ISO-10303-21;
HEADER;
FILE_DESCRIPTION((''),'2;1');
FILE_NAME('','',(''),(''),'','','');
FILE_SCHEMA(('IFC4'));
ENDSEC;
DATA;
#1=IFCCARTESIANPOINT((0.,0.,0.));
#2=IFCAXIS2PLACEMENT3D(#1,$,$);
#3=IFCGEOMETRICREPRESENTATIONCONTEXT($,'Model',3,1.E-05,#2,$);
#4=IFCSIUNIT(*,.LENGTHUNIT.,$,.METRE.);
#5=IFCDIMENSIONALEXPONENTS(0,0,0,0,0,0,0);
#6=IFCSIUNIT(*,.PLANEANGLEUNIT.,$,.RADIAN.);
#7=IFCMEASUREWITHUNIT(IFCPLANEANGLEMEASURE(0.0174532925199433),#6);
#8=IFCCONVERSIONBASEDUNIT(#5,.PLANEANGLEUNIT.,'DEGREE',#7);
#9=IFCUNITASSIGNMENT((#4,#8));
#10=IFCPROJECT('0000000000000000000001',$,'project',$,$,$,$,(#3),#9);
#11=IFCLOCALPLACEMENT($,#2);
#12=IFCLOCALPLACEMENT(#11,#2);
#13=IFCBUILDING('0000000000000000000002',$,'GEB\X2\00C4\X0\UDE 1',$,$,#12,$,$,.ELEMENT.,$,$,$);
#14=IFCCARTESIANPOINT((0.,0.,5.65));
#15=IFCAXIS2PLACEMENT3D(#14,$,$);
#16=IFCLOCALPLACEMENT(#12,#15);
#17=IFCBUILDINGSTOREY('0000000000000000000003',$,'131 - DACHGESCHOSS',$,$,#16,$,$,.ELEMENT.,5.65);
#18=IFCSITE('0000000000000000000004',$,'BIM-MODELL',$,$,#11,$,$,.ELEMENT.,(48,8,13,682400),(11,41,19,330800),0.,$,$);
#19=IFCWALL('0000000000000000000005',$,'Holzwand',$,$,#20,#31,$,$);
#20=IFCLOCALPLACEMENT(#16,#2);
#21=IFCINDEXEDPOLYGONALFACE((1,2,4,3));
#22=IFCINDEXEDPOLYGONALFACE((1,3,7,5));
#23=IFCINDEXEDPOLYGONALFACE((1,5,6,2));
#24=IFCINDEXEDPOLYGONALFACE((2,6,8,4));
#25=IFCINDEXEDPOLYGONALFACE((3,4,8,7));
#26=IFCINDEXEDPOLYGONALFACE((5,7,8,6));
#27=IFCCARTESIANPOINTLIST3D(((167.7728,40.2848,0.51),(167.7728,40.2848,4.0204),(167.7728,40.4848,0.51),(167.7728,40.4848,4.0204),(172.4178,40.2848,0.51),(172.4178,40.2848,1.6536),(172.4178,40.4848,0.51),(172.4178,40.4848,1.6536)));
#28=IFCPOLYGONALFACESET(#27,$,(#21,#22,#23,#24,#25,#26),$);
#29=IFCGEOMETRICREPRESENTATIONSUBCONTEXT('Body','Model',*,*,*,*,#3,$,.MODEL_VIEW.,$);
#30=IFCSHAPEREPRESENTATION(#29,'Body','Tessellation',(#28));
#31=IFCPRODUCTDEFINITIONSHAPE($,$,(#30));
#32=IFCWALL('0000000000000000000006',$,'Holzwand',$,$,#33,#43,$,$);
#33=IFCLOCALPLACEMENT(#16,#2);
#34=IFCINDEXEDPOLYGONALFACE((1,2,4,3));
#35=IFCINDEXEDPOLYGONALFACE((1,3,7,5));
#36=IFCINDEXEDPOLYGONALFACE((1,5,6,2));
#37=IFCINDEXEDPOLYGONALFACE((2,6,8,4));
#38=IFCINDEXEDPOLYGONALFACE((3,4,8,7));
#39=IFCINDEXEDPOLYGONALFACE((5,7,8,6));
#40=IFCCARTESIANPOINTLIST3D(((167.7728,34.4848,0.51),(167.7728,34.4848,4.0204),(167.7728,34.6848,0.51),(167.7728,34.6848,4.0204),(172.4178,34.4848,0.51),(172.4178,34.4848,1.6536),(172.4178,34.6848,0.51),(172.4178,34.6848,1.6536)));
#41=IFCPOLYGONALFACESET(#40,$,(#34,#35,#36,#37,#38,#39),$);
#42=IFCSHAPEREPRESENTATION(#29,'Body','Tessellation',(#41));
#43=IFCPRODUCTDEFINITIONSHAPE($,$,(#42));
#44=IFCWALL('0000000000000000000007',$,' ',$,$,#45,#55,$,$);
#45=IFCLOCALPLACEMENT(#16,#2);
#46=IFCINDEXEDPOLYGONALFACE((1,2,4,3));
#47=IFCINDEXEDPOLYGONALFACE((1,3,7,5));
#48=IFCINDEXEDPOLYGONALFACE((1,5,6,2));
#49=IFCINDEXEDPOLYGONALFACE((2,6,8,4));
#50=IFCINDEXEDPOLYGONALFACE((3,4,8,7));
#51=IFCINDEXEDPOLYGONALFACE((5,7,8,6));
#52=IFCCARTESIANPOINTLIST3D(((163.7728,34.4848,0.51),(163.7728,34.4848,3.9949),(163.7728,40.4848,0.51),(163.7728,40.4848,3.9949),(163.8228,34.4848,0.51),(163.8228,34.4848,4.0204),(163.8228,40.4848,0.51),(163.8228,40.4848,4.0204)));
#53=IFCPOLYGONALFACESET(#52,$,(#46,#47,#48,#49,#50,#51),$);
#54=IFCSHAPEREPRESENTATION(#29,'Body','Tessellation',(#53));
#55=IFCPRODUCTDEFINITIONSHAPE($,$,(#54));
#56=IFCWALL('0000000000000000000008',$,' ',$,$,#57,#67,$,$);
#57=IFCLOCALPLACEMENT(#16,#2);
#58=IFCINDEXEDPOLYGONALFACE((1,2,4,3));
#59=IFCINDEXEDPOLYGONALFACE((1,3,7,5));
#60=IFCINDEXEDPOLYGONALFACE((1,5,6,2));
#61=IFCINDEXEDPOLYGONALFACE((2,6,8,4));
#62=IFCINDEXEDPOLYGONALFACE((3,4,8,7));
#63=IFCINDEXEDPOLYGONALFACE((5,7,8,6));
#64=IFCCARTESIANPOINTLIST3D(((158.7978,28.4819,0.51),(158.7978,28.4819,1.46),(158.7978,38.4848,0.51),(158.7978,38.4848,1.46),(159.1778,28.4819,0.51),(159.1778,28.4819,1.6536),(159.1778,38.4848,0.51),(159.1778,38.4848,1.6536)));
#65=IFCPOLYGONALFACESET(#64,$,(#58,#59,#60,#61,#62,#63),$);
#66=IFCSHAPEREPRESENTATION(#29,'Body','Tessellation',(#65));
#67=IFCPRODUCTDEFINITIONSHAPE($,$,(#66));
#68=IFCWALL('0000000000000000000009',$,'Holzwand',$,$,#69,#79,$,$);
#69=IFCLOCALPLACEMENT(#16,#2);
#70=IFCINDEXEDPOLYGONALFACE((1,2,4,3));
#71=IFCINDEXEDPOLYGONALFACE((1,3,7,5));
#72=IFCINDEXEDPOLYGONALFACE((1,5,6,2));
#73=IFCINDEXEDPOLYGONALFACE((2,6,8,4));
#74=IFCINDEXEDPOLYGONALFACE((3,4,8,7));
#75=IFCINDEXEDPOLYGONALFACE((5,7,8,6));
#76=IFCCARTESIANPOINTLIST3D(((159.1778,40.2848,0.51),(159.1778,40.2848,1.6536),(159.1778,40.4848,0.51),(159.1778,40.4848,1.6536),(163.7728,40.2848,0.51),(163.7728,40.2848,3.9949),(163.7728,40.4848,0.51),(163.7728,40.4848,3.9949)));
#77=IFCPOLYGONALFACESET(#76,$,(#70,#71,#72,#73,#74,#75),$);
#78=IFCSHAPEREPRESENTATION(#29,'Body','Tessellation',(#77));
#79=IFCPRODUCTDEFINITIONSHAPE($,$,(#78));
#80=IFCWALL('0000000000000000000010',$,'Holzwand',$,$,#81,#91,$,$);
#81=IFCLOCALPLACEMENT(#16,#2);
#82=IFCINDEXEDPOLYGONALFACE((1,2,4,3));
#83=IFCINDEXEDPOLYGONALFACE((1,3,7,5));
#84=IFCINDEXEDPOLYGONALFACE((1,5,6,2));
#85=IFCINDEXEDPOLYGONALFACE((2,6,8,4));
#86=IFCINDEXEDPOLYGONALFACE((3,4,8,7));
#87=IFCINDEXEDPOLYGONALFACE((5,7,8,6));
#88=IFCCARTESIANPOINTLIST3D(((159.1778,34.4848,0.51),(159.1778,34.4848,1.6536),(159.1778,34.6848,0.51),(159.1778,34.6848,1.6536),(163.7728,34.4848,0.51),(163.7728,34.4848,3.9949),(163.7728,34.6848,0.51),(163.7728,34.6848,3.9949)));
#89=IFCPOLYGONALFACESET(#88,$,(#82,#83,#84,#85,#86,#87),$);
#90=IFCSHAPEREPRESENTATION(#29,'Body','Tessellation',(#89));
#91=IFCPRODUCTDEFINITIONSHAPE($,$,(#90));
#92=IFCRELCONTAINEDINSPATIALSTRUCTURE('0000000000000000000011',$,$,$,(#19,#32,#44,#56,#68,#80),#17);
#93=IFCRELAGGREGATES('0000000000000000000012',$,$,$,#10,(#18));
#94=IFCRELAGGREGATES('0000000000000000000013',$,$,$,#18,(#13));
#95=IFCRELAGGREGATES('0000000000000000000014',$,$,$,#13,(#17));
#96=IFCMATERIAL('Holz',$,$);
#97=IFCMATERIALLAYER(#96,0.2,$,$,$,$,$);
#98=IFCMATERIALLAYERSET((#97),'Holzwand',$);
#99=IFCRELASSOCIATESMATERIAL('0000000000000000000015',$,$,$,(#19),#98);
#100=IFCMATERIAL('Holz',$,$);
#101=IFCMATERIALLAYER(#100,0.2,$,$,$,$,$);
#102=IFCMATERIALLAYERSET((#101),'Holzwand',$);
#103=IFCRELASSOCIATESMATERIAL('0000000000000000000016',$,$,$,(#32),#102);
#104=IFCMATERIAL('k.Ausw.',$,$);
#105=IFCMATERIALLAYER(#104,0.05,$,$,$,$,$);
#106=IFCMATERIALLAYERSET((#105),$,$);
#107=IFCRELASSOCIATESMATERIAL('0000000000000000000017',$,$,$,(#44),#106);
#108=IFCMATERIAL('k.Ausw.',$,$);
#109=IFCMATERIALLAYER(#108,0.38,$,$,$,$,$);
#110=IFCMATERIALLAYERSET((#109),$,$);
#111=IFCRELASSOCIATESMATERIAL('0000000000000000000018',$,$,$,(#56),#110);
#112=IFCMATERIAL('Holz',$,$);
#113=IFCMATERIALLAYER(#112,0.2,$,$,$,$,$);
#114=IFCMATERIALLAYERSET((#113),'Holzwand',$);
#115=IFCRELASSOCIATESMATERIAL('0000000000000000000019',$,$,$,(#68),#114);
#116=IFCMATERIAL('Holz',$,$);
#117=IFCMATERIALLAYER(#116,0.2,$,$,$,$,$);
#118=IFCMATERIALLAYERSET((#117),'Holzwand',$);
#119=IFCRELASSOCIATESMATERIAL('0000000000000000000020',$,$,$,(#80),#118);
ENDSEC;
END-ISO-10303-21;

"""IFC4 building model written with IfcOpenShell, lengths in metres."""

from ifc_helpers import new_model, entity, si_unit, converted_unit, frame, frame_2d, origin, origin_with_axes, place, context, subcontext, project, spatial, rectangle, extrude, clip, halfspace, material, layer, layer_set, layer_usage, element, save


model = new_model("IFC4")

# Units and contexts
model_context = context("Model", 3, precision=1e-05, world=origin())
body_context = subcontext(model_context, "Body", "Model", "MODEL_VIEW")
ifc_project = project(units=[si_unit("LENGTHUNIT", "METRE"), converted_unit("PLANEANGLEUNIT", "DEGREE", entity("IfcPlaneAngleMeasure", 0.0174532925199433), si_unit("PLANEANGLEUNIT", "RADIAN"), dimensions=[0, 0, 0, 0, 0, 0, 0])], contexts=[model_context])

# Site, building, storey
site_placement = place(None, origin())
site = spatial("IfcSite", under=ifc_project, at=site_placement, Name="BIM-MODELL", CompositionType="ELEMENT", RefLatitude=(48, 8, 13, 682400), RefLongitude=(11, 41, 19, 330800), RefElevation=0.0)
building_placement = place(site_placement, origin())
building = spatial("IfcBuilding", under=site, at=building_placement, Name="GEBÄUDE 1", CompositionType="ELEMENT")
storey_placement = place(building_placement, frame((0.0, 0.0, 5.65)))
storey = spatial("IfcBuildingStorey", under=building, at=storey_placement, Name="131 - DACHGESCHOSS", CompositionType="ELEMENT", Elevation=5.65)

# Walls
ifc_material_1 = material(Name="Holz")
ifc_layer_1 = layer(ifc_material_1, 0.2)
ifc_layer_set_1 = layer_set([ifc_layer_1], Name="Holzwand")
ifc_layer_usage_1 = layer_usage(ifc_layer_set_1, "AXIS2", "POSITIVE", 0.0)
wall_1_placement = place(storey_placement, frame((172.4178, 40.4848, 0.51), z_axis=(0.0, 0.0, 1.0), x_axis=(-1.0, 0.0, 0.0)))
element("IfcWall", 1, at=wall_1_placement, inside=storey, material=ifc_layer_usage_1, Name="Holzwand", context=body_context, shape_type="Clipping", body=[
    clip(extrude(rectangle(XDim=4.645, YDim=0.2, at=frame_2d((2.3225, 0.1), x_axis=(1.0, 0.0))), origin_with_axes(), (0.0, 0.0, 1.0), 3.5104), halfspace(frame((2.3225, 0.1, 2.327), z_axis=(0.45399, 0.0, -0.891007), x_axis=(0.891007, 0.0, 0.45399)), True)),
])
ifc_material_2 = material(Name="Holz")
ifc_layer_2 = layer(ifc_material_2, 0.2)
ifc_layer_set_2 = layer_set([ifc_layer_2], Name="Holzwand")
ifc_layer_usage_2 = layer_usage(ifc_layer_set_2, "AXIS2", "POSITIVE", 0.0)
wall_2_placement = place(storey_placement, frame((167.7728, 34.4848, 0.51)))
element("IfcWall", 2, at=wall_2_placement, inside=storey, material=ifc_layer_usage_2, Name="Holzwand", context=body_context, shape_type="Clipping", body=[
    clip(extrude(rectangle(XDim=4.645, YDim=0.2, at=frame_2d((2.3225, 0.1), x_axis=(1.0, 0.0))), origin_with_axes(), (0.0, 0.0, 1.0), 3.5104), halfspace(frame((2.3225, 0.1, 2.327), z_axis=(-0.45399, 0.0, -0.891007), x_axis=(0.891007, 0.0, -0.45399)), True)),
])
ifc_material_3 = material(Name="k.Ausw.")
ifc_layer_3 = layer(ifc_material_3, 0.05)
ifc_layer_set_3 = layer_set([ifc_layer_3])
ifc_layer_usage_3 = layer_usage(ifc_layer_set_3, "AXIS2", "POSITIVE", 0.0)
wall_3_placement = place(storey_placement, frame((163.7728, 40.4848, 0.51), z_axis=(0.0, 0.0, 1.0), x_axis=(0.0, -1.0, 0.0)))
element("IfcWall", 3, at=wall_3_placement, inside=storey, material=ifc_layer_usage_3, Name=" ", context=body_context, shape_type="Clipping", body=[
    clip(extrude(rectangle(XDim=6.0, YDim=0.05, at=frame_2d((3.0, 0.025), x_axis=(1.0, 0.0))), origin_with_axes(), (0.0, 0.0, 1.0), 3.5104), halfspace(frame((3.0, 0.025, 3.4976), z_axis=(0.0, 0.45399, -0.891007), x_axis=(1.0, 0.0, 0.0)), True)),
])
ifc_material_4 = material(Name="k.Ausw.")
ifc_layer_4 = layer(ifc_material_4, 0.38)
ifc_layer_set_4 = layer_set([ifc_layer_4])
ifc_layer_usage_4 = layer_usage(ifc_layer_set_4, "AXIS2", "POSITIVE", 0.0)
wall_4_placement = place(storey_placement, frame((158.7978, 38.4848, 0.51), z_axis=(0.0, 0.0, 1.0), x_axis=(0.0, -1.0, 0.0)))
element("IfcWall", 4, at=wall_4_placement, inside=storey, material=ifc_layer_usage_4, Name=" ", context=body_context, shape_type="Clipping", body=[
    clip(extrude(rectangle(XDim=10.0029, YDim=0.38, at=frame_2d((5.0014, 0.19), x_axis=(1.0, 0.0))), origin_with_axes(), (0.0, 0.0, 1.0), 1.1436), halfspace(frame((5.0014, 0.19, 1.0468), z_axis=(0.0, 0.45399, -0.891007), x_axis=(0.0, -0.891007, -0.45399)), True)),
])
ifc_material_5 = material(Name="Holz")
ifc_layer_5 = layer(ifc_material_5, 0.2)
ifc_layer_set_5 = layer_set([ifc_layer_5], Name="Holzwand")
ifc_layer_usage_5 = layer_usage(ifc_layer_set_5, "AXIS2", "POSITIVE", 0.0)
wall_5_placement = place(storey_placement, frame((163.7728, 40.4848, 0.51), z_axis=(0.0, 0.0, 1.0), x_axis=(-1.0, 0.0, 0.0)))
element("IfcWall", 5, at=wall_5_placement, inside=storey, material=ifc_layer_usage_5, Name="Holzwand", context=body_context, shape_type="Clipping", body=[
    clip(extrude(rectangle(XDim=4.595, YDim=0.2, at=frame_2d((2.2975, 0.1), x_axis=(1.0, 0.0))), origin_with_axes(), (0.0, 0.0, 1.0), 3.4849), halfspace(frame((2.2975, 0.1, 2.3143), z_axis=(-0.45399, 0.0, -0.891007), x_axis=(0.891007, 0.0, -0.45399)), True)),
])
ifc_material_6 = material(Name="Holz")
ifc_layer_6 = layer(ifc_material_6, 0.2)
ifc_layer_set_6 = layer_set([ifc_layer_6], Name="Holzwand")
ifc_layer_usage_6 = layer_usage(ifc_layer_set_6, "AXIS2", "POSITIVE", 0.0)
wall_6_placement = place(storey_placement, frame((159.1778, 34.4848, 0.51)))
element("IfcWall", 6, at=wall_6_placement, inside=storey, material=ifc_layer_usage_6, Name="Holzwand", context=body_context, shape_type="Clipping", body=[
    clip(extrude(rectangle(XDim=4.595, YDim=0.2, at=frame_2d((2.2975, 0.1), x_axis=(1.0, 0.0))), origin_with_axes(), (0.0, 0.0, 1.0), 3.4849), halfspace(frame((2.2975, 0.1, 2.3143), z_axis=(0.45399, 0.0, -0.891007), x_axis=(0.891007, 0.0, 0.45399)), True)),
])

save(model, "model.ifc")
